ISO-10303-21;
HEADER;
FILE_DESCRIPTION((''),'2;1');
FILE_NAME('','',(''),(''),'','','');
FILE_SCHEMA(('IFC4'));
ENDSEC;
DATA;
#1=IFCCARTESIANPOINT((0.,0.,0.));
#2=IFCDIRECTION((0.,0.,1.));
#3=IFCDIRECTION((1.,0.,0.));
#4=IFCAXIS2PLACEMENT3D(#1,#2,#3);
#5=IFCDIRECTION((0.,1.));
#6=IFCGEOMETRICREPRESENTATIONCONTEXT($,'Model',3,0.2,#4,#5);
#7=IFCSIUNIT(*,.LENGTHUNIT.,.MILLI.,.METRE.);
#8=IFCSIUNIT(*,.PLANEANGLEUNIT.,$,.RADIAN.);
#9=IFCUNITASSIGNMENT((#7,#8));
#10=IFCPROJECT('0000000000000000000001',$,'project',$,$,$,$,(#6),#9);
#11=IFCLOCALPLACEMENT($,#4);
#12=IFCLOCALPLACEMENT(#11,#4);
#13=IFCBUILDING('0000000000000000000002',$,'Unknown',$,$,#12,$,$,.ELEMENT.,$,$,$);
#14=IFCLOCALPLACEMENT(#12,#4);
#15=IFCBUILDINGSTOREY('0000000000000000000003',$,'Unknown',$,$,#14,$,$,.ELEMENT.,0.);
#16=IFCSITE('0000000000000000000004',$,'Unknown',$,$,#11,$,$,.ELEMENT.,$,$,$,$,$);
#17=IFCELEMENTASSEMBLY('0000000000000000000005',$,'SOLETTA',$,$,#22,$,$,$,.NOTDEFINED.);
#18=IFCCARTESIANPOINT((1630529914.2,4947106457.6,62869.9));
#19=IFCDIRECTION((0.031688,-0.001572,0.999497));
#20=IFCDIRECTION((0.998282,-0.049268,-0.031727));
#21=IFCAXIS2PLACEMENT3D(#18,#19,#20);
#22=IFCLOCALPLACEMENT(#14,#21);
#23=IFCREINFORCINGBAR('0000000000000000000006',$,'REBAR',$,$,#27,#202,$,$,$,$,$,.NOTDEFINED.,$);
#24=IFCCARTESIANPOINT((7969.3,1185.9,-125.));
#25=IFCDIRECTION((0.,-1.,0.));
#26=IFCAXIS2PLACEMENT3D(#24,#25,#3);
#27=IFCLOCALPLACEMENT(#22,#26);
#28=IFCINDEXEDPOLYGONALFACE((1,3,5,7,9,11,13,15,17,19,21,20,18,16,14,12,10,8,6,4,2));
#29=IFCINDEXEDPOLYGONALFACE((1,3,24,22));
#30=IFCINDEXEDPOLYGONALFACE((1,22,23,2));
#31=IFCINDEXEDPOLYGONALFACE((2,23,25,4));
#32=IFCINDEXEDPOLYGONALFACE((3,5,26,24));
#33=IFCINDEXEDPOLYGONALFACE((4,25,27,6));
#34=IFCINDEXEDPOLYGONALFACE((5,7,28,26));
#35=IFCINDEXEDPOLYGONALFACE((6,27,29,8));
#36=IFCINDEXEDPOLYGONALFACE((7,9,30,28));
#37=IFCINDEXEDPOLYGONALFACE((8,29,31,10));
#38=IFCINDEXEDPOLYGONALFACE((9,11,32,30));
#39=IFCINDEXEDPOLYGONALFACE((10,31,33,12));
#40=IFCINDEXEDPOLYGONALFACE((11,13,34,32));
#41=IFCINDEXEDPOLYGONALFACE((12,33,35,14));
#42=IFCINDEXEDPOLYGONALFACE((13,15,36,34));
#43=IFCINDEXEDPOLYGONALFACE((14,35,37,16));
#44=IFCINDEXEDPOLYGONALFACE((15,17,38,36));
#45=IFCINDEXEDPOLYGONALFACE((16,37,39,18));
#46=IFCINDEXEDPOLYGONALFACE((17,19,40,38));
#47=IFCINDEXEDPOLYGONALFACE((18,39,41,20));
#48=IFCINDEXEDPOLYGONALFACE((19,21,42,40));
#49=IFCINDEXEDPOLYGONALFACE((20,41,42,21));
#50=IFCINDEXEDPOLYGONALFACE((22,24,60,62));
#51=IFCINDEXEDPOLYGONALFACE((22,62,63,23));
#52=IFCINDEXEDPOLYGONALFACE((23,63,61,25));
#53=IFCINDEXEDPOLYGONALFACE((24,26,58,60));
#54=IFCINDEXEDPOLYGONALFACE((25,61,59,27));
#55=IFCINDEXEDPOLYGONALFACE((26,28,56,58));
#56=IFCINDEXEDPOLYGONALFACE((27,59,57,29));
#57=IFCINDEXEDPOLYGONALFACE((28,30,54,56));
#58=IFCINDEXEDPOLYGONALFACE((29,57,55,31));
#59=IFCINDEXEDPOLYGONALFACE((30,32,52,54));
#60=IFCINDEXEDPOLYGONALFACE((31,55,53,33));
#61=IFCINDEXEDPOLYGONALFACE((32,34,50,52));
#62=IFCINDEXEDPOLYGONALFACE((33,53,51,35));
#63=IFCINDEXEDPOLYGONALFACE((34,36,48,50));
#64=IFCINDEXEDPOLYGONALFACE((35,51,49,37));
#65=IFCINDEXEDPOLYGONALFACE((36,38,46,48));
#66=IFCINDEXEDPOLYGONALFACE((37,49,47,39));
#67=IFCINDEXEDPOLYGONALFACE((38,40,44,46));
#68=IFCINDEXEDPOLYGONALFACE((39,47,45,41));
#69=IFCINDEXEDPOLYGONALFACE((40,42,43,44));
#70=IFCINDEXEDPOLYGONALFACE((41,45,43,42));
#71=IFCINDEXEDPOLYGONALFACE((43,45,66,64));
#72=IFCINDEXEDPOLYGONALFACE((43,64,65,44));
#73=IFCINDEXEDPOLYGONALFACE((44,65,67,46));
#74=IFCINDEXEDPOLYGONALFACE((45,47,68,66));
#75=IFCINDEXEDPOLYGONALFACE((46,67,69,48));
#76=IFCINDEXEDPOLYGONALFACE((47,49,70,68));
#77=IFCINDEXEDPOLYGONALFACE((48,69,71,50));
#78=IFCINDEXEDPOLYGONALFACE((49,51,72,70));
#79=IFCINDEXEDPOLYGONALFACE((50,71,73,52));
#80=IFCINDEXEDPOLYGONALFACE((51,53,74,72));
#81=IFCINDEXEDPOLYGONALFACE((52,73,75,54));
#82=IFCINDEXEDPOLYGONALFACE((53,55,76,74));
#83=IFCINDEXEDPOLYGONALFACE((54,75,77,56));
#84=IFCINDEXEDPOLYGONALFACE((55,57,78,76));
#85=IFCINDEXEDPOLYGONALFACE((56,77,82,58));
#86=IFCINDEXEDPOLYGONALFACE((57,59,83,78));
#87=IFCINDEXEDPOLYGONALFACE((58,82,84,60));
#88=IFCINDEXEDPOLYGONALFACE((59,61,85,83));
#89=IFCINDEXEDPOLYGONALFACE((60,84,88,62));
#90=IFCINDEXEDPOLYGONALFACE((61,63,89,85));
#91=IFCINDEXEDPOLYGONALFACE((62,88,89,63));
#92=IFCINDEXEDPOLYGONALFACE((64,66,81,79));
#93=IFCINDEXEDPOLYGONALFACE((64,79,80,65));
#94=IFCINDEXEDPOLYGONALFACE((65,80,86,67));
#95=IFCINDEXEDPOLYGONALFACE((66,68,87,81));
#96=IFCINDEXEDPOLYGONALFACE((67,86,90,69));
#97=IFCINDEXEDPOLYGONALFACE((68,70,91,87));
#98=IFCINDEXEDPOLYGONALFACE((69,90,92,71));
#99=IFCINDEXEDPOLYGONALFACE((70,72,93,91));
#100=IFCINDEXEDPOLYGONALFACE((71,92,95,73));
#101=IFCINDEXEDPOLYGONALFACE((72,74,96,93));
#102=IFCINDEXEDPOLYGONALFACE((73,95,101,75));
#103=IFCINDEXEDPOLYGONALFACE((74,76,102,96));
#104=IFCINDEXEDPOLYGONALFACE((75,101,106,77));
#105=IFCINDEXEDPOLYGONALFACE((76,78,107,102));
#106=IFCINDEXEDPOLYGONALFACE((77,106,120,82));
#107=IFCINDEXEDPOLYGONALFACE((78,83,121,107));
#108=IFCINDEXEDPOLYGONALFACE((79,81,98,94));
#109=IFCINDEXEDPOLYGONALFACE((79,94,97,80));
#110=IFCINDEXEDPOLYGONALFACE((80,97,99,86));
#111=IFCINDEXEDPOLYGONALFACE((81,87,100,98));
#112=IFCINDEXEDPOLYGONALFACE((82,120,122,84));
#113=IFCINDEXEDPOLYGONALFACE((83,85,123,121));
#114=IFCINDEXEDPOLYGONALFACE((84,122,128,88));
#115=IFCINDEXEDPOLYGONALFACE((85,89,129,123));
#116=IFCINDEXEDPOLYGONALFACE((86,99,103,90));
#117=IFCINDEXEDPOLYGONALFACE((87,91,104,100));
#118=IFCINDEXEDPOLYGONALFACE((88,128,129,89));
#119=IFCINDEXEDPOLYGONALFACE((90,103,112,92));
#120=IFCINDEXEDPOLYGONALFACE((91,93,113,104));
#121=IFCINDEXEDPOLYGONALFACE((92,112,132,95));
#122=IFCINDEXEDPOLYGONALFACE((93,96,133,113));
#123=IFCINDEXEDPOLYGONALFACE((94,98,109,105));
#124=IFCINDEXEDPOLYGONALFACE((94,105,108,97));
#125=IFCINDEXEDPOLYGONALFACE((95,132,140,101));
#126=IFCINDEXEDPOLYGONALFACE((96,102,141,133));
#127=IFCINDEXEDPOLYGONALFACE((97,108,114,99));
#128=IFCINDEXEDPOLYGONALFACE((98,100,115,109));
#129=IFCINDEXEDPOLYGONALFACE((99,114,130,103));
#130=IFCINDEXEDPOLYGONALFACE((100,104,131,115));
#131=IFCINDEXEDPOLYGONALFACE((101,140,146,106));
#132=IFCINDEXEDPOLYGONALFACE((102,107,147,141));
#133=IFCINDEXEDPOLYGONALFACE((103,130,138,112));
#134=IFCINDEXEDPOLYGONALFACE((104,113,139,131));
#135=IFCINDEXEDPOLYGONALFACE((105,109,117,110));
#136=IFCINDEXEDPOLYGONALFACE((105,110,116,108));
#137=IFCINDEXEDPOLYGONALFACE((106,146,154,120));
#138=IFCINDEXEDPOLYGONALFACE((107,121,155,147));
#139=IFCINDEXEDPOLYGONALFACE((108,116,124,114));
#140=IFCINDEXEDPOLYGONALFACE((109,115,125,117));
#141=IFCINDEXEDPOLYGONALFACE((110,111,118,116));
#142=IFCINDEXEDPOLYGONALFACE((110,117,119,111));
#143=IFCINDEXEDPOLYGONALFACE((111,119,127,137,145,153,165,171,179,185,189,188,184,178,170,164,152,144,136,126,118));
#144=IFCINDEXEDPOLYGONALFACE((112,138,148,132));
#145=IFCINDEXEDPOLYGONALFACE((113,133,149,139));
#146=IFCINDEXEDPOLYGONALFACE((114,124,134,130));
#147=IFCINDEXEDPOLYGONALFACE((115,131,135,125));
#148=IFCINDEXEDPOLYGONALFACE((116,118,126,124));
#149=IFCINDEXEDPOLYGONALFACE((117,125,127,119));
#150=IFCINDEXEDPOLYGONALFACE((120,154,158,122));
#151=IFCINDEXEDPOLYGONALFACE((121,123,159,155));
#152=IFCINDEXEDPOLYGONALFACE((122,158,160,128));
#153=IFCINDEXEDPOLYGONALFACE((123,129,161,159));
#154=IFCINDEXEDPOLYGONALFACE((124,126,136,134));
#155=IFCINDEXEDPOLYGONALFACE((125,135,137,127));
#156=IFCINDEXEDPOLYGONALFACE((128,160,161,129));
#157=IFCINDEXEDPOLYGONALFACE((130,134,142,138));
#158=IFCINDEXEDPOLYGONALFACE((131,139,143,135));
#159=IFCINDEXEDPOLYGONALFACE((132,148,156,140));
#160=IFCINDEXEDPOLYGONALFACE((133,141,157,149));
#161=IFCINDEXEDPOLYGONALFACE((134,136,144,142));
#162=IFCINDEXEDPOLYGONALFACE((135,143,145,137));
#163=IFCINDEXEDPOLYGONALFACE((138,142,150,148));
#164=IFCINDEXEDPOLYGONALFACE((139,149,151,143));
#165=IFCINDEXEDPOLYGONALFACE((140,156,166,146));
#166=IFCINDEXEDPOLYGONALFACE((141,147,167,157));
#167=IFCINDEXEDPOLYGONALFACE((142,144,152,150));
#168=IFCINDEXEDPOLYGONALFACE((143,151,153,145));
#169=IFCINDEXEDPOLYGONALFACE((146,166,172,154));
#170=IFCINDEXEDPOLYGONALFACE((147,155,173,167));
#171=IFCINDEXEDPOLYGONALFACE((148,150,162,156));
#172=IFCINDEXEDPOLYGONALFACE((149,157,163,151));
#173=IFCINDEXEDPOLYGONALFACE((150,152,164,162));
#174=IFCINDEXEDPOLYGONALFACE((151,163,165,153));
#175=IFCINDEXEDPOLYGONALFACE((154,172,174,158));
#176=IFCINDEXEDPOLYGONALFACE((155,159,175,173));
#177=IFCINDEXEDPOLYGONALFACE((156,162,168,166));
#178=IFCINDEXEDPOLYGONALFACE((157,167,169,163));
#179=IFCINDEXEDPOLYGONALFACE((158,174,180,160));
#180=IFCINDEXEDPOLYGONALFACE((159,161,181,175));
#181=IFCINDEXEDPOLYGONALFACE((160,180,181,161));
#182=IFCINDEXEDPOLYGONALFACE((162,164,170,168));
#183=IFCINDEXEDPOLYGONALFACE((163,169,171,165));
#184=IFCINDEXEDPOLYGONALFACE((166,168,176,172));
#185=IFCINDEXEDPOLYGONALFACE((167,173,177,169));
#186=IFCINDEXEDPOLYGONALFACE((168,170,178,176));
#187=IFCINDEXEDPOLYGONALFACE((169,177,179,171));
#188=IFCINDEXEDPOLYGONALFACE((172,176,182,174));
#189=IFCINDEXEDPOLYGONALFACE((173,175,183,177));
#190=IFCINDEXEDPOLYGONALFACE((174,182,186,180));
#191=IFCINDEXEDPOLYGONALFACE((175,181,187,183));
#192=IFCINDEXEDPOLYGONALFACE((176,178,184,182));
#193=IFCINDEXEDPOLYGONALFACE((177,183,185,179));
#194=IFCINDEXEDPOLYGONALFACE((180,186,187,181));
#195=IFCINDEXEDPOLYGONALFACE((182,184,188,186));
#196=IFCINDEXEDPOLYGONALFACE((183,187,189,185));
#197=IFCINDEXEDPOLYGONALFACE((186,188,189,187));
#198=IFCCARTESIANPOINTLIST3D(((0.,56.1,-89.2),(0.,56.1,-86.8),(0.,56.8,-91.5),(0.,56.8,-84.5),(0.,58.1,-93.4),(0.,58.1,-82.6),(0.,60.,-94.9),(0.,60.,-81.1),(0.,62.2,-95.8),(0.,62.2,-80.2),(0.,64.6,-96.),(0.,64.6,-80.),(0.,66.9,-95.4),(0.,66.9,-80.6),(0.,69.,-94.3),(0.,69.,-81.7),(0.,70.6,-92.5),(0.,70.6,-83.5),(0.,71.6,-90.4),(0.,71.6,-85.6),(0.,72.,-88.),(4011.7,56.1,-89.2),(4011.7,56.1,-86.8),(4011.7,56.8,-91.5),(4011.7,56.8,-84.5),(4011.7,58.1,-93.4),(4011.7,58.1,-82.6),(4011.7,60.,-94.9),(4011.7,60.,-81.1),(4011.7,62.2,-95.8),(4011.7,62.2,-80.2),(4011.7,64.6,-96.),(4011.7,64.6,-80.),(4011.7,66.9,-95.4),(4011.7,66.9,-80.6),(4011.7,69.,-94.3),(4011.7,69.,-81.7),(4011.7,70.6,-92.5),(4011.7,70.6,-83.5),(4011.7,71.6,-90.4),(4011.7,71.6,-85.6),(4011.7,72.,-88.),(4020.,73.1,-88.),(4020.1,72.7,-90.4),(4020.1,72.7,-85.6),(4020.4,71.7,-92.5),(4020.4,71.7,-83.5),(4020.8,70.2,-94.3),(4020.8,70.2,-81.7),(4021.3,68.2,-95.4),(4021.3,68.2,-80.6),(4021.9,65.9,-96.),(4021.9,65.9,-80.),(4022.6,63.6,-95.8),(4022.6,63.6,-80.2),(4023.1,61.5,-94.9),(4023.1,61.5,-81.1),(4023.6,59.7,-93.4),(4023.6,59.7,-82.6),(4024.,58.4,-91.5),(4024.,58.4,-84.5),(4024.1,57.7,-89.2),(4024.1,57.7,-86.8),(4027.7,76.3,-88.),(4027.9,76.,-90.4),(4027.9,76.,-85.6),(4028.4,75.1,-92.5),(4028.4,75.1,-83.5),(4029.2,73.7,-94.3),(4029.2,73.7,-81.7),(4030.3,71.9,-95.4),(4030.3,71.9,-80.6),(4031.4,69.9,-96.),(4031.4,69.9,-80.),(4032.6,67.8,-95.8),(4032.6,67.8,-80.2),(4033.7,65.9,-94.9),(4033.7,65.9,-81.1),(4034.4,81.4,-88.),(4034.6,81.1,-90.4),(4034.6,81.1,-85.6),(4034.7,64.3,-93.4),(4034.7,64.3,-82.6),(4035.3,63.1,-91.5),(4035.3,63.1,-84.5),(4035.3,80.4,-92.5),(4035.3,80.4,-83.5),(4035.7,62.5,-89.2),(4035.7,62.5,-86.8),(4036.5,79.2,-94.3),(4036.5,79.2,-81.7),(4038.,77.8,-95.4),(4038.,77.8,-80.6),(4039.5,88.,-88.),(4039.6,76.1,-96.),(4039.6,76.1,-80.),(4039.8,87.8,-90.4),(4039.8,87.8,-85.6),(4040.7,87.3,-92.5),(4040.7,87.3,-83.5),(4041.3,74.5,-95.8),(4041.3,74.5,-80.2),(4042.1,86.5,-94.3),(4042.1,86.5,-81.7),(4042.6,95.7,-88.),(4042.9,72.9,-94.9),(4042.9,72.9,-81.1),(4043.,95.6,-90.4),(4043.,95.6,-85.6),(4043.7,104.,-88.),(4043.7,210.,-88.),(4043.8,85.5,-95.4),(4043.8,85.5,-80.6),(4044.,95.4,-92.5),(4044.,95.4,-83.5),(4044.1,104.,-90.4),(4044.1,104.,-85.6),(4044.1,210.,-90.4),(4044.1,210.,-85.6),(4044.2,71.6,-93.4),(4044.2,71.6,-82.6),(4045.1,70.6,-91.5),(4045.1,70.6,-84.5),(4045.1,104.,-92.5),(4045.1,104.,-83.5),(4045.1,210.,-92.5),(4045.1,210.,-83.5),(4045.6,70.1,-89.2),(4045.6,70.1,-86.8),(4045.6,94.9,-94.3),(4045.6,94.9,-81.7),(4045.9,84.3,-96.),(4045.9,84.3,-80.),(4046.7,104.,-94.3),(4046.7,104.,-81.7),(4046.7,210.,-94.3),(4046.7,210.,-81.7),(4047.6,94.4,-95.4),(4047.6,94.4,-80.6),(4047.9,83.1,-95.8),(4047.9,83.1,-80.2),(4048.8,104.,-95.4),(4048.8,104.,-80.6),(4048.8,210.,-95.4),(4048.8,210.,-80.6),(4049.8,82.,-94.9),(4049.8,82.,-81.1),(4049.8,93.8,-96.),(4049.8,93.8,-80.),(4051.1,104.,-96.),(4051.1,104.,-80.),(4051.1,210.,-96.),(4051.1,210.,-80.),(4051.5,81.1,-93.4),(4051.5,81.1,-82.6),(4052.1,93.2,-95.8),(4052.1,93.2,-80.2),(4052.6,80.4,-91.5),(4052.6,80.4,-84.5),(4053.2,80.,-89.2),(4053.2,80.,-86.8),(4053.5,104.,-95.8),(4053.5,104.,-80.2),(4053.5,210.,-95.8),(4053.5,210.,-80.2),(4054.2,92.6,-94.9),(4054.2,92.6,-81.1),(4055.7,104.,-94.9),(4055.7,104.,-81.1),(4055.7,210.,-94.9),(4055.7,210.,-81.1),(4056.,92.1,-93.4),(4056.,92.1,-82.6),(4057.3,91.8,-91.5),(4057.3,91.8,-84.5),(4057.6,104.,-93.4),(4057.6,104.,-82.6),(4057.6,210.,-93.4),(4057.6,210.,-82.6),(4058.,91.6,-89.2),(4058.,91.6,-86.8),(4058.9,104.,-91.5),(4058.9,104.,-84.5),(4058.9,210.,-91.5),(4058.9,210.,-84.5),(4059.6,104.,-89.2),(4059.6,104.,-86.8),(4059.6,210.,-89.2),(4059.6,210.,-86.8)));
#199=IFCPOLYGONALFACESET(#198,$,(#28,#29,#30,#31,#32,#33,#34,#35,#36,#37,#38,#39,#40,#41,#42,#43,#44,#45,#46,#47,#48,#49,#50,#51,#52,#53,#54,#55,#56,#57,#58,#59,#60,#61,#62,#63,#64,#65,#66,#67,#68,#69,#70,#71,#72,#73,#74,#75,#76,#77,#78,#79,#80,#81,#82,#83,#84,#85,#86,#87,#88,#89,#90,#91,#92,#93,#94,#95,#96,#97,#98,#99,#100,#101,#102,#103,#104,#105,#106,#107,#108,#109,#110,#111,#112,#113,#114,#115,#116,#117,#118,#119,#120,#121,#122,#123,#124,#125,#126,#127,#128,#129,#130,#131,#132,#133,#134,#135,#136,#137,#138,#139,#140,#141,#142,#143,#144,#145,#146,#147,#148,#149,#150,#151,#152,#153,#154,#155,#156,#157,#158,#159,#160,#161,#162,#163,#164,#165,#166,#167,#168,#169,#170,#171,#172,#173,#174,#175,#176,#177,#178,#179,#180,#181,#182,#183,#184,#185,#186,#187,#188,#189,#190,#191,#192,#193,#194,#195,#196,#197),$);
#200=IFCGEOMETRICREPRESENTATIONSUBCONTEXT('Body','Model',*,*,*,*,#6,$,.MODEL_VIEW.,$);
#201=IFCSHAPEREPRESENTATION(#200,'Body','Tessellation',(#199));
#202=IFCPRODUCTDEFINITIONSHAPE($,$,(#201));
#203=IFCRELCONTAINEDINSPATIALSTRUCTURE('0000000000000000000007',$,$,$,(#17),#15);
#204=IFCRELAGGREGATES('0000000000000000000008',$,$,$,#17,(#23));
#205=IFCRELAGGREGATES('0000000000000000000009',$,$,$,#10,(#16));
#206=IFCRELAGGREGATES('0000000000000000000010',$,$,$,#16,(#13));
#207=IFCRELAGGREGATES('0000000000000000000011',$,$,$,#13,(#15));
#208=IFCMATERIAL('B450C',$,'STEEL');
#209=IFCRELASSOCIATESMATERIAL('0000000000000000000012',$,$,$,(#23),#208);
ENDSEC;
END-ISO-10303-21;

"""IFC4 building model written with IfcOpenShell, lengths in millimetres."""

from ifc_helpers import new_model, entity, si_unit, direction, frame, origin_with_axes, place, context, subcontext, project, spatial, material, element, aggregate, save


model = new_model("IFC4")

# Units and contexts
model_context = context("Model", 3, precision=0.2, world=origin_with_axes(), true_north=direction((0.0, 1.0)))
body_context = subcontext(model_context, "Body", "Model", "MODEL_VIEW")
ifc_project = project(units=[si_unit("LENGTHUNIT", "METRE", prefix="MILLI"), si_unit("PLANEANGLEUNIT", "RADIAN")], contexts=[model_context])

# Site, building, storey
site_placement = place(None, origin_with_axes())
site = spatial("IfcSite", under=ifc_project, at=site_placement, Name="Unknown", CompositionType="ELEMENT")
building_placement = place(site_placement, origin_with_axes())
building = spatial("IfcBuilding", under=site, at=building_placement, Name="Unknown", CompositionType="ELEMENT")
storey_placement = place(building_placement, origin_with_axes())
storey = spatial("IfcBuildingStorey", under=building, at=storey_placement, Name="Unknown", CompositionType="ELEMENT", Elevation=0.0)

# Element assembly, reinforcing bar
ifc_material = material(Name="B450C", Category="STEEL")
assembly_1_placement = place(storey_placement, frame((1630529914.2, 4947106457.6, 62869.9), z_axis=(0.031688, -0.001572, 0.999497), x_axis=(0.998282, -0.049268, -0.031727)))
assembly_1 = element("IfcElementAssembly", 1, at=assembly_1_placement, inside=storey, Name="SOLETTA", PredefinedType="NOTDEFINED")
reinforcing_bar_1_placement = place(assembly_1_placement, frame((7969.3, 1185.9, -125.0), z_axis=(0.0, -1.0, 0.0), x_axis=(1.0, 0.0, 0.0)))
reinforcing_bar_1 = element("IfcReinforcingBar", 2, at=reinforcing_bar_1_placement, material=ifc_material, Name="REBAR", PredefinedType="NOTDEFINED", context=body_context, shape_type="AdvancedSweptSolid", body=[
    entity("IfcSweptDiskSolid", entity("IfcIndexedPolyCurve", entity("IfcCartesianPointList3D", [[0.0, 64.0, -88.0], [4011.7, 64.0, -88.0], [4040.0, 75.7, -88.0], [4051.7, 104.0, -88.0], [4051.7, 210.0, -88.0]]), [entity("IfcLineIndex", [1, 2]), entity("IfcArcIndex", [2, 3, 4]), entity("IfcLineIndex", [4, 5])]), 8.0),
])
aggregate(assembly_1, [reinforcing_bar_1])

save(model, "model.ifc")
